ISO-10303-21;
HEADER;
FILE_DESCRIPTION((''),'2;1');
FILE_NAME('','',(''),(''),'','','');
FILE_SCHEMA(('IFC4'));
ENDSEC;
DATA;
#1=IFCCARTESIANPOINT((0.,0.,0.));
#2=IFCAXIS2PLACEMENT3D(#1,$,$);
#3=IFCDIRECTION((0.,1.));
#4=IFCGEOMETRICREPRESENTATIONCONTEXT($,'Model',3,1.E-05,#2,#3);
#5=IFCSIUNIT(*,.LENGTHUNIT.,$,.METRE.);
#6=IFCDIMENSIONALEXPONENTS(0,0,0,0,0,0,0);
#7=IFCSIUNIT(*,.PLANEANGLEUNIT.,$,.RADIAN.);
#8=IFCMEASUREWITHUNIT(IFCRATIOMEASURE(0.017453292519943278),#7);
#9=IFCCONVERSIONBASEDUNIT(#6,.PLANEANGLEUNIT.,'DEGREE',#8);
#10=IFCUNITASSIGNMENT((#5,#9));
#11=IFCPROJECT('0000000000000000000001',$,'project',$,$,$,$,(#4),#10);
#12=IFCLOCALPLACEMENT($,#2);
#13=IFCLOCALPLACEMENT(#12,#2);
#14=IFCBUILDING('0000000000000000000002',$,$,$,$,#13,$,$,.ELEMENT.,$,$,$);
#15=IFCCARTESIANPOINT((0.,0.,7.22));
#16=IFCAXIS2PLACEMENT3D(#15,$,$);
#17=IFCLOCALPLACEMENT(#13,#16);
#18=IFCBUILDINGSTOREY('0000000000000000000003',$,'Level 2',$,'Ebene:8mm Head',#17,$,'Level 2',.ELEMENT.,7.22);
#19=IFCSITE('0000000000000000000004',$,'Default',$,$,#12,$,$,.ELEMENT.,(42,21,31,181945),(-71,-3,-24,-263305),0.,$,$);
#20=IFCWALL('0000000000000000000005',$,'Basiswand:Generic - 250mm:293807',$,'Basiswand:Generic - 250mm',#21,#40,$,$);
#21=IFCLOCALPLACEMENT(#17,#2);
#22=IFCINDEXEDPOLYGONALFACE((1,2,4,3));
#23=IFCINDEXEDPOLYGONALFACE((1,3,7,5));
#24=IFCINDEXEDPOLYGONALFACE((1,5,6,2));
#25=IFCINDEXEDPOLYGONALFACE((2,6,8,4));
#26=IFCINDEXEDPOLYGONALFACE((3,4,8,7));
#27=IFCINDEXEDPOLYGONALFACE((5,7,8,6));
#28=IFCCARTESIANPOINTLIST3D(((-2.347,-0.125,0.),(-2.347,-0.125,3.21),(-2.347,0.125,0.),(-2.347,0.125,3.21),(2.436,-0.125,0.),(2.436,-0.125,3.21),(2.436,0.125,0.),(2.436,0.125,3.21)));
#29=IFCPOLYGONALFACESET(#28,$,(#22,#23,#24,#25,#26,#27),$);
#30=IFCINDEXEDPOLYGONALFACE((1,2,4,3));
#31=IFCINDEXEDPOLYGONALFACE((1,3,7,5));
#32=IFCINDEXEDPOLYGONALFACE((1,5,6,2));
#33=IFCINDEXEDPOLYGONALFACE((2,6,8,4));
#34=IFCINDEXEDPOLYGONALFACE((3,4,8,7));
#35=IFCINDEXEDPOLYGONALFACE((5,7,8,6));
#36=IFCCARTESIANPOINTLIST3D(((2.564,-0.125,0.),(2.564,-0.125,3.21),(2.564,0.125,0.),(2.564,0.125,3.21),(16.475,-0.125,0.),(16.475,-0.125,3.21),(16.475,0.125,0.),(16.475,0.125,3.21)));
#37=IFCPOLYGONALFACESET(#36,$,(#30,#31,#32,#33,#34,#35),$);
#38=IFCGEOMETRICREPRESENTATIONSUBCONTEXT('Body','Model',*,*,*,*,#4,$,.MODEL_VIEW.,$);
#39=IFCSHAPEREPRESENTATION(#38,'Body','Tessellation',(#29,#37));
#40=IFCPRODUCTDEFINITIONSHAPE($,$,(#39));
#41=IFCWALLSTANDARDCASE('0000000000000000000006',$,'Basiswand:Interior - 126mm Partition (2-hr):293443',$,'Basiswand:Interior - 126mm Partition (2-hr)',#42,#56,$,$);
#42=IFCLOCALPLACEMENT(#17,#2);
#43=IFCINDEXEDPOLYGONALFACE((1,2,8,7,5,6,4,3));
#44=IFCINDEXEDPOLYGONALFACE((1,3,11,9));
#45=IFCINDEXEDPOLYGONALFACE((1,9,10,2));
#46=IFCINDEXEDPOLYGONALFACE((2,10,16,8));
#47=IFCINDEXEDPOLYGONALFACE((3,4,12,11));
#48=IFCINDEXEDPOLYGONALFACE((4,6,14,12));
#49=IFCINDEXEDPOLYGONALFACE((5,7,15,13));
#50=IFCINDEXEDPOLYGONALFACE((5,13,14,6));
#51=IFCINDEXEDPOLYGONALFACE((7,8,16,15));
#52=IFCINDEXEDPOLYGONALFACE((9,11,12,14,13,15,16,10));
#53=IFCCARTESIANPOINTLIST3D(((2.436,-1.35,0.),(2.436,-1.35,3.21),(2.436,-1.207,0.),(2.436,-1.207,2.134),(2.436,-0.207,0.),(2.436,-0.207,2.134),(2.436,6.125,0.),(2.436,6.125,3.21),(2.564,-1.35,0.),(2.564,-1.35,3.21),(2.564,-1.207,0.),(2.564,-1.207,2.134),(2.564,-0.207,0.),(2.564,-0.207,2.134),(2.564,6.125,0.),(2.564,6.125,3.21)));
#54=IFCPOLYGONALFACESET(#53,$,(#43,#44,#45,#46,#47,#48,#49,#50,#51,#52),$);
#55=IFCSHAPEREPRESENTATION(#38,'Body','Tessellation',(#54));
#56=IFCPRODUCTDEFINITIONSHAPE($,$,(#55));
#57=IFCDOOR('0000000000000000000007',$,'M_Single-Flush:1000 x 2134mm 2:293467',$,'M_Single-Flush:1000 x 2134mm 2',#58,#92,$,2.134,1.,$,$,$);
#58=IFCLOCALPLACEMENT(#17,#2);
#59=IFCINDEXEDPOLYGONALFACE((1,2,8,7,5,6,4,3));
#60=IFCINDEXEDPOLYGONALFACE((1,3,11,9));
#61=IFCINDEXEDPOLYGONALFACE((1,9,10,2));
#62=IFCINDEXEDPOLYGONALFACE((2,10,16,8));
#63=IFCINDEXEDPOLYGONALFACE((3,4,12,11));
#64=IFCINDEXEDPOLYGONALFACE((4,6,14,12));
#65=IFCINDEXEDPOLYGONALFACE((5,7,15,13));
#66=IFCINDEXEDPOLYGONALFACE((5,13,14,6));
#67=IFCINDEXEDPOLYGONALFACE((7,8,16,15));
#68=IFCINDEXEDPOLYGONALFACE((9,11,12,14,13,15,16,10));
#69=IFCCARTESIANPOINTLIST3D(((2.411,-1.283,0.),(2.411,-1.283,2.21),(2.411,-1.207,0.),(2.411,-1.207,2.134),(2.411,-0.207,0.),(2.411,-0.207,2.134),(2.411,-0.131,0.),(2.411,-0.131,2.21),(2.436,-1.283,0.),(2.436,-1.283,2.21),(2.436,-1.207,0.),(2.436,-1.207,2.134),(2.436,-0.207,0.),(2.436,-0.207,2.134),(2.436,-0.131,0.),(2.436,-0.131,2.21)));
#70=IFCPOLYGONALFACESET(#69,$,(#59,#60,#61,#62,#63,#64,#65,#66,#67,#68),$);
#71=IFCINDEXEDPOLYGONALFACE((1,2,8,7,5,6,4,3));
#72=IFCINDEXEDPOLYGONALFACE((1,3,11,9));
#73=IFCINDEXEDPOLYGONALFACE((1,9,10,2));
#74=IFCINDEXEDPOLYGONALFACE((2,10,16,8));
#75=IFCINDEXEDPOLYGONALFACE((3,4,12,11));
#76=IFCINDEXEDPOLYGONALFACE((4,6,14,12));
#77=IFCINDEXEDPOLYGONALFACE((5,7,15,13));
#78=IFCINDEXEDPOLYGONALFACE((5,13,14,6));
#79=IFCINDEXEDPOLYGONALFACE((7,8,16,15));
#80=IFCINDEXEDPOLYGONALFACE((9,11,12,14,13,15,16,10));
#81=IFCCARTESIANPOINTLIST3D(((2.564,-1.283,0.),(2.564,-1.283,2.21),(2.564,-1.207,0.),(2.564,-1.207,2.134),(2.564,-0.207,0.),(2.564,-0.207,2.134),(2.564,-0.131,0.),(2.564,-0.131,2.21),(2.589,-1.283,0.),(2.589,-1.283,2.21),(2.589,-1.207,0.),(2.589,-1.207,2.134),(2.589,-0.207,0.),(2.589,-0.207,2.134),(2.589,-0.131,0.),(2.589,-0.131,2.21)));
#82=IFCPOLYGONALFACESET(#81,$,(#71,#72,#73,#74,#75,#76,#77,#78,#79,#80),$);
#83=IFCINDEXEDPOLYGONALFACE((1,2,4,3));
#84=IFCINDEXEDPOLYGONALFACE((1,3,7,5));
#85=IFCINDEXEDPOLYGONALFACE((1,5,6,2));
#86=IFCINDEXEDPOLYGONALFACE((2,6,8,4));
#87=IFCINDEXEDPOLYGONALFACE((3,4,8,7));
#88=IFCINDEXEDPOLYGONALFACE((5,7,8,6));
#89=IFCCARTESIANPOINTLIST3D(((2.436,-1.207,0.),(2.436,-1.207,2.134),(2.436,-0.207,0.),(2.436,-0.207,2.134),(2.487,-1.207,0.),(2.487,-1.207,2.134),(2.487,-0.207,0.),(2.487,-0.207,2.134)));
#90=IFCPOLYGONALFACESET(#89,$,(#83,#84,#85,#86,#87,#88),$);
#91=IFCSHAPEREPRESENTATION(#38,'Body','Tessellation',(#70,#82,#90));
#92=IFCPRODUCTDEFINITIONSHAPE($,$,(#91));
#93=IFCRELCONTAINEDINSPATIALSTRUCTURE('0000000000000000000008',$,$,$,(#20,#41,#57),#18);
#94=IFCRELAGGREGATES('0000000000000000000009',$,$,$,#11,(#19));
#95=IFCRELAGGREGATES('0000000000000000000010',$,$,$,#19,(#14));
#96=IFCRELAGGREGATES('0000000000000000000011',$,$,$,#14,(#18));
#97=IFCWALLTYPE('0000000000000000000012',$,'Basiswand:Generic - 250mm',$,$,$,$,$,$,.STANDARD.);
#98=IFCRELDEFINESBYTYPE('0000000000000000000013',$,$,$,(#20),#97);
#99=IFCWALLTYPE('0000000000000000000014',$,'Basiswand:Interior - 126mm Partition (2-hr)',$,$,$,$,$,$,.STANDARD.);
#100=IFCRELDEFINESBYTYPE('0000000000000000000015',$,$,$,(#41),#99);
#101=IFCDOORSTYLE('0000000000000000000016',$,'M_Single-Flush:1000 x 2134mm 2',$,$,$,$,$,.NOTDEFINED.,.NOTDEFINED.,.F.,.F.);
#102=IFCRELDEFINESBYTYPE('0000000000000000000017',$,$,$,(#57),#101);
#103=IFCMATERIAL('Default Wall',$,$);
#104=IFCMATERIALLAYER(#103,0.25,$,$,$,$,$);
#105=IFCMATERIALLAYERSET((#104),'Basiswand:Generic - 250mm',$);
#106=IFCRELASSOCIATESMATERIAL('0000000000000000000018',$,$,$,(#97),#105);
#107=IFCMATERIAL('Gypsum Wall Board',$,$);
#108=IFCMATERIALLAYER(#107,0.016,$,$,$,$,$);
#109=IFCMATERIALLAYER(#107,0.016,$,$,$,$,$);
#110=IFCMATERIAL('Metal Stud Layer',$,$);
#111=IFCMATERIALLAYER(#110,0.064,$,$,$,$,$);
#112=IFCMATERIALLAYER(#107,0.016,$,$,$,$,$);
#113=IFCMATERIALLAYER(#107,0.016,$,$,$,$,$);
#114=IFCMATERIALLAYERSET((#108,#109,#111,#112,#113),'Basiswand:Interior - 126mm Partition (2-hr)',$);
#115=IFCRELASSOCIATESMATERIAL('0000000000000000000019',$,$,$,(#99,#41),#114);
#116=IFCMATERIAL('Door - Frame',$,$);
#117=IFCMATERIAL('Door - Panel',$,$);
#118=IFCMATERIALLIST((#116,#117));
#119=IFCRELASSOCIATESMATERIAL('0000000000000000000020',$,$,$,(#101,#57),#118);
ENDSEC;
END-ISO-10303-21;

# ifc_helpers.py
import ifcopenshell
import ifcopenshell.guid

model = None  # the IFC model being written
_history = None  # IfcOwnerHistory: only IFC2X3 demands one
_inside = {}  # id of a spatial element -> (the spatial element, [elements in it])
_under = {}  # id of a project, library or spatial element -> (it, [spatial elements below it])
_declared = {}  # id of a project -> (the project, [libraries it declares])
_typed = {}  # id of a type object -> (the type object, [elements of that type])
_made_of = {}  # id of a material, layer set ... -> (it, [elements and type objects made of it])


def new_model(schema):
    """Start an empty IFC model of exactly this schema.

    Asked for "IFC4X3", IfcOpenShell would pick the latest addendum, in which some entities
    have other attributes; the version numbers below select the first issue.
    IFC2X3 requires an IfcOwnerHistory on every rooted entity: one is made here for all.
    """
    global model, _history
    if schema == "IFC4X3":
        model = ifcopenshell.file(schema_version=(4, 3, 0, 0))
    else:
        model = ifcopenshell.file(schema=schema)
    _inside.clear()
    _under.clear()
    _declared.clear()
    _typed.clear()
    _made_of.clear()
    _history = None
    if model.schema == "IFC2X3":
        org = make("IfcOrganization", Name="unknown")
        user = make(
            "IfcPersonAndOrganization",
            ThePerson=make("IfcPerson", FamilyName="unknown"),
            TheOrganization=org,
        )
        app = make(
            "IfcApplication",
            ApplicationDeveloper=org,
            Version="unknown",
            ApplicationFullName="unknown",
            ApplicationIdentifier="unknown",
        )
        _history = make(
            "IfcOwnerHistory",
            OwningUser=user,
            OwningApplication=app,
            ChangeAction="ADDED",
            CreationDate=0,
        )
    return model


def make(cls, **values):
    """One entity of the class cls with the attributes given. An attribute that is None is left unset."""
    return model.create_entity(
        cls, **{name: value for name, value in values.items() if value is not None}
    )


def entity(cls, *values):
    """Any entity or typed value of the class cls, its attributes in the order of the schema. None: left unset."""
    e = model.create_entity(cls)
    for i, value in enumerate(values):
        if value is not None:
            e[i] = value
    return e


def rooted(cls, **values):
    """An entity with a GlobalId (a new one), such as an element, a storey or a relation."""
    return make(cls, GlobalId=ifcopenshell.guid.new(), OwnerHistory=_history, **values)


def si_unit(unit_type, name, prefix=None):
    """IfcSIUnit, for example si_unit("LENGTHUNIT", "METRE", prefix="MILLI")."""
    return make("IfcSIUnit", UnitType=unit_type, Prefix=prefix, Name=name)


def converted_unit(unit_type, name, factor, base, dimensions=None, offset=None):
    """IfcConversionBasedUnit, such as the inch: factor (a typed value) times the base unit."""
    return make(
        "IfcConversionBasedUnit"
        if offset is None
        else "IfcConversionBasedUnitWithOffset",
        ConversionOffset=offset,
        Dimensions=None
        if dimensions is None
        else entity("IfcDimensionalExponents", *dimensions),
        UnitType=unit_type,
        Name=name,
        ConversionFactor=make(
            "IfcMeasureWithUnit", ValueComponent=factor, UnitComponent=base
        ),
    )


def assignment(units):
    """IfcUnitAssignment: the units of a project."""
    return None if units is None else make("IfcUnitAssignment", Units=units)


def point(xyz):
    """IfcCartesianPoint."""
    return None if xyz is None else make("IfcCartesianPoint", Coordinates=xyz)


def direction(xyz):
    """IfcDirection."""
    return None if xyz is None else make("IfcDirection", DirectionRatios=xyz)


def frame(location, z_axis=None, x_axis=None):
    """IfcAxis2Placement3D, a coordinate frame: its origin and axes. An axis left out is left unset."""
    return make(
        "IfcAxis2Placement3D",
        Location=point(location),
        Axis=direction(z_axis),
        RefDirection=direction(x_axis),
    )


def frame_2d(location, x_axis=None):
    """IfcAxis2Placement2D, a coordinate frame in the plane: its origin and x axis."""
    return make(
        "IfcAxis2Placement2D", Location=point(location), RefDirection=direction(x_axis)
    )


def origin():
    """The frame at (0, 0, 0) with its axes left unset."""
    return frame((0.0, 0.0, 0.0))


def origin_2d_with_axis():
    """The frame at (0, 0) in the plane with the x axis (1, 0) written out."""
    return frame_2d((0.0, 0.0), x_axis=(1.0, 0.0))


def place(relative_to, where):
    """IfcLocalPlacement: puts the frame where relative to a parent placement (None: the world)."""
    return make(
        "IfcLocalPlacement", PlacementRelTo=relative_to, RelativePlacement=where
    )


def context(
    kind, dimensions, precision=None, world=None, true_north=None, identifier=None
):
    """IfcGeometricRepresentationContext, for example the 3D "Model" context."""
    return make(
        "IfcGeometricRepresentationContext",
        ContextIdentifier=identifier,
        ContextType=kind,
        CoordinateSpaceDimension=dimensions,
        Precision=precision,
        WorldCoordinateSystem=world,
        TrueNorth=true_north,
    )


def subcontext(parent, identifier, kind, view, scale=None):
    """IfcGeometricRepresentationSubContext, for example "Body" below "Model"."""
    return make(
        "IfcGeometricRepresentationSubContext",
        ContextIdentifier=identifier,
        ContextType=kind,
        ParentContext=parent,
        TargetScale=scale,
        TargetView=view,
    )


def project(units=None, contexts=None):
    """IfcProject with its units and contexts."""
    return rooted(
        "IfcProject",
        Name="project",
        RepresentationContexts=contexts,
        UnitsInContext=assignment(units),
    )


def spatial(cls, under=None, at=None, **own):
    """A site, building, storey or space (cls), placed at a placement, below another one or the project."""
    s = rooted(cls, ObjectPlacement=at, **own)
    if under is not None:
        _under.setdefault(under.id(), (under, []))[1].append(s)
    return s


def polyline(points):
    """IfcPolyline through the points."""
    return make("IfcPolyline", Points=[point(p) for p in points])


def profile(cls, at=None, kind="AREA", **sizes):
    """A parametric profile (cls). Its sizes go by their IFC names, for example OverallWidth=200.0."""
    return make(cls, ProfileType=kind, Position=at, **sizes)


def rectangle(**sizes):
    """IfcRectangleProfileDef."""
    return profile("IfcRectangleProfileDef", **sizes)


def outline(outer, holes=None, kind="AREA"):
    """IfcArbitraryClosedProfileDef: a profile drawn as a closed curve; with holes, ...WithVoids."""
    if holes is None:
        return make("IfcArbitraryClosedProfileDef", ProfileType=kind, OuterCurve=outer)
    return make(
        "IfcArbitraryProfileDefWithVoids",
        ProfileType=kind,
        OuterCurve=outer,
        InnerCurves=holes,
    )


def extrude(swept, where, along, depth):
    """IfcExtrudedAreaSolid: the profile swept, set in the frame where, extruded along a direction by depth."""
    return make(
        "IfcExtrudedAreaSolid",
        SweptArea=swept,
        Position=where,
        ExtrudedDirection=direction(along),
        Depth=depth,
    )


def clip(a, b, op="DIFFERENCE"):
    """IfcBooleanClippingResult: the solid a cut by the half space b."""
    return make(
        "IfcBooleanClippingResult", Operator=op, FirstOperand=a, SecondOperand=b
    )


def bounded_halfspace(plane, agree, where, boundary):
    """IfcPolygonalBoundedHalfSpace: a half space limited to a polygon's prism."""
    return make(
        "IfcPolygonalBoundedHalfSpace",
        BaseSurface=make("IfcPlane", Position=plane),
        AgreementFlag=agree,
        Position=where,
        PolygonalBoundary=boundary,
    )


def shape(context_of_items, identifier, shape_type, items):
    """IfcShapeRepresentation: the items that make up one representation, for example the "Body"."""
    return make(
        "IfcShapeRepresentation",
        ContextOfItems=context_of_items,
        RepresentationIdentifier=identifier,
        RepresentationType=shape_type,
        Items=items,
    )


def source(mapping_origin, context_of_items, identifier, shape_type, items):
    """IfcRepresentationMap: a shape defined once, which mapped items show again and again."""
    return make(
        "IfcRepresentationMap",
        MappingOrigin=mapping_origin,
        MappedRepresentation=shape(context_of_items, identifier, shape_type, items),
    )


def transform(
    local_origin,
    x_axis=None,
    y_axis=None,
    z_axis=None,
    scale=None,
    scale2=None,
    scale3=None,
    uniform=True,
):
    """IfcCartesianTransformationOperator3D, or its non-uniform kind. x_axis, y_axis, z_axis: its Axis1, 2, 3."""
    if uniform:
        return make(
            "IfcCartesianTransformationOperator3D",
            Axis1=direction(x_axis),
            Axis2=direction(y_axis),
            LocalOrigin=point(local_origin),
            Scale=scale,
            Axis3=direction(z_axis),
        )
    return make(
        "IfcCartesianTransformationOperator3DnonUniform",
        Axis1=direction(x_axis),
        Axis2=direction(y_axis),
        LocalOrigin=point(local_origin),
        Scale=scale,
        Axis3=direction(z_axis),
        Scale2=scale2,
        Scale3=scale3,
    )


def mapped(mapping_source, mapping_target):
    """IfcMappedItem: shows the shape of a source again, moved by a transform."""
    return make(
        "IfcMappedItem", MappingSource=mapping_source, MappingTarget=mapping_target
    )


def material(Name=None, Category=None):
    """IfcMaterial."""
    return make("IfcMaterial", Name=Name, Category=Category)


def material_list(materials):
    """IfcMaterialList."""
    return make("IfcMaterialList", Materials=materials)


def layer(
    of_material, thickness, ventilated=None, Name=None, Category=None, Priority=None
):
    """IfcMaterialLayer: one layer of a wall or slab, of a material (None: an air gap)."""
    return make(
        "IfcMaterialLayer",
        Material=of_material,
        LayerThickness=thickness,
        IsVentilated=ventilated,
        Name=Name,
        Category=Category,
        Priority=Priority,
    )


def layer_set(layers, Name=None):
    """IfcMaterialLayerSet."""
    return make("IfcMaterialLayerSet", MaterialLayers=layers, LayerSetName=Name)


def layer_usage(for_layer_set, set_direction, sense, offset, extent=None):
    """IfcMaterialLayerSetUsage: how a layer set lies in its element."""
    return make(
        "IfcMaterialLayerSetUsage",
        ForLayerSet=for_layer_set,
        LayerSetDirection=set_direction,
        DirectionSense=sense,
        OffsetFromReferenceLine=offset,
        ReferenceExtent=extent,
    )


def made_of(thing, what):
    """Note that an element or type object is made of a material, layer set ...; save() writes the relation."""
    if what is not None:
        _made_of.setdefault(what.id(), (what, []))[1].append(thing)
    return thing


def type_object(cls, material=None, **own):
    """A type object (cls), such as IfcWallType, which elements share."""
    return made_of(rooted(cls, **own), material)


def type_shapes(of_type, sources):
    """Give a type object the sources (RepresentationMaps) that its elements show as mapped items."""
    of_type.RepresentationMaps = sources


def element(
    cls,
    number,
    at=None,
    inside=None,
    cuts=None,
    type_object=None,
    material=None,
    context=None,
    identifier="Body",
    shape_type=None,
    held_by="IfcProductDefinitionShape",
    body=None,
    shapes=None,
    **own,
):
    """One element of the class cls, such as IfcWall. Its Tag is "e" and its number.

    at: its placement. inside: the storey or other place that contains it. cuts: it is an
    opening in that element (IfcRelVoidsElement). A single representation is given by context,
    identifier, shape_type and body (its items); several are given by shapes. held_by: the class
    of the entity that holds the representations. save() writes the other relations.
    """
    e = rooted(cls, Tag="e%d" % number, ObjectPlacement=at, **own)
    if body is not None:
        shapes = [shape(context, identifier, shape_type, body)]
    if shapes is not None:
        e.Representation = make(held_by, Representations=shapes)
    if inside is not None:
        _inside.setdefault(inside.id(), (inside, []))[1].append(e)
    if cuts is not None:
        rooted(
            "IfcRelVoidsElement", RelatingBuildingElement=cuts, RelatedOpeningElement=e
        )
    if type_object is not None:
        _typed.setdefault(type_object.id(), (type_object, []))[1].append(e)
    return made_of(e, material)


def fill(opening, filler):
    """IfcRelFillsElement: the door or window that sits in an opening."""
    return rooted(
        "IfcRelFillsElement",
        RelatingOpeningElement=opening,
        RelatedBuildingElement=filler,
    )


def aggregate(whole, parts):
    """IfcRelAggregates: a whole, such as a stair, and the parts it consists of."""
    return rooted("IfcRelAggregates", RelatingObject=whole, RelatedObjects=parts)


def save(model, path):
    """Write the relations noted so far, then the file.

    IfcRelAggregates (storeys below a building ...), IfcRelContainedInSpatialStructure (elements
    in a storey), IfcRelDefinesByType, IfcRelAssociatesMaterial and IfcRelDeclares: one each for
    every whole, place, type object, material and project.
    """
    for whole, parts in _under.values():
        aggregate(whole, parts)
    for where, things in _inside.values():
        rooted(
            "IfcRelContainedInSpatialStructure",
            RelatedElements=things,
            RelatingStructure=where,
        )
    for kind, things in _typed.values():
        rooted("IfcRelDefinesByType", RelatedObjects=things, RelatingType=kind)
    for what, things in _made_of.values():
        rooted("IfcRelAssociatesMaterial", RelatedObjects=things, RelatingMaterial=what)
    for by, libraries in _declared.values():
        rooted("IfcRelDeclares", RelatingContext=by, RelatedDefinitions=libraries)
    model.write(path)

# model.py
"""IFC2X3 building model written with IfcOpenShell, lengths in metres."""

from ifc_helpers import new_model, entity, si_unit, converted_unit, direction, frame, frame_2d, origin, origin_2d_with_axis, place, context, subcontext, project, spatial, polyline, rectangle, outline, extrude, clip, bounded_halfspace, source, transform, mapped, material, material_list, layer, layer_set, layer_usage, type_object, type_shapes, element, fill, save


model = new_model("IFC2X3")

# Units and contexts
model_context = context("Model", 3, precision=1e-05, world=origin(), true_north=direction((0.0, 1.0)))
body_context = subcontext(model_context, "Body", "Model", "MODEL_VIEW")
ifc_project = project(units=[si_unit("LENGTHUNIT", "METRE"), converted_unit("PLANEANGLEUNIT", "DEGREE", entity("IfcRatioMeasure", 0.017453292519943278), si_unit("PLANEANGLEUNIT", "RADIAN"), dimensions=[0, 0, 0, 0, 0, 0, 0])], contexts=[model_context])

# Site, building, storey
site_placement = place(None, origin())
site = spatial("IfcSite", under=ifc_project, at=site_placement, Name="Default", CompositionType="ELEMENT", RefLatitude=(42, 21, 31, 181945), RefLongitude=(-71, -3, -24, -263305), RefElevation=0.0)
building_placement = place(site_placement, origin())
building = spatial("IfcBuilding", under=site, at=building_placement, CompositionType="ELEMENT")
storey_placement = place(building_placement, frame((0.0, 0.0, 7.22)))
storey = spatial("IfcBuildingStorey", under=building, at=storey_placement, Name="Level 2", ObjectType="Ebene:8mm Head", LongName="Level 2", CompositionType="ELEMENT", Elevation=7.22)

# Wall
ifc_material_1 = material(Name="Default Wall")
ifc_layer_1 = layer(ifc_material_1, 0.25)
ifc_layer_set_1 = layer_set([ifc_layer_1], Name="Basiswand:Generic - 250mm")
wall_type_1 = type_object("IfcWallType", Name="Basiswand:Generic - 250mm", PredefinedType="STANDARD", material=ifc_layer_set_1)
wall_1_placement = place(storey_placement, frame((-2.347, 0.0, 0.0)))
element("IfcWall", 1, at=wall_1_placement, inside=storey, type_object=wall_type_1, Name="Basiswand:Generic - 250mm:293807", ObjectType="Basiswand:Generic - 250mm", context=body_context, shape_type="SweptSolid", body=[
    extrude(rectangle(XDim=4.783, YDim=0.25, at=frame_2d((0.0, 0.0), x_axis=(1.0, 0.0))), frame((2.3915, 0.0, 0.0)), (0.0, 0.0, 1.0), 3.21),
    extrude(rectangle(XDim=13.911, YDim=0.25, at=origin_2d_with_axis()), frame((11.8665, 0.0, 0.0), z_axis=(0.0, 0.0, 1.0), x_axis=(-1.0, 0.0, 0.0)), (0.0, 0.0, 1.0), 3.21),
])

# Wall, opening, door
ifc_material_2 = material(Name="Gypsum Wall Board")
ifc_layer_2 = layer(ifc_material_2, 0.016)
ifc_layer_3 = layer(ifc_material_2, 0.016)
ifc_material_3 = material(Name="Metal Stud Layer")
ifc_layer_4 = layer(ifc_material_3, 0.064)
ifc_layer_5 = layer(ifc_material_2, 0.016)
ifc_layer_6 = layer(ifc_material_2, 0.016)
ifc_layer_set_2 = layer_set([ifc_layer_2, ifc_layer_3, ifc_layer_4, ifc_layer_5, ifc_layer_6], Name="Basiswand:Interior - 126mm Partition (2-hr)")
ifc_layer_usage_1 = layer_usage(ifc_layer_set_2, "AXIS2", "POSITIVE", -0.064)
wall_type_2 = type_object("IfcWallType", Name="Basiswand:Interior - 126mm Partition (2-hr)", PredefinedType="STANDARD", material=ifc_layer_set_2)
wall_2_placement = place(storey_placement, frame((2.5, -1.35, 0.0), z_axis=(0.0, 0.0, 1.0), x_axis=(0.0, 1.0, 0.0)))
wall_2 = element("IfcWallStandardCase", 2, at=wall_2_placement, inside=storey, type_object=wall_type_2, material=ifc_layer_usage_1, Name="Basiswand:Interior - 126mm Partition (2-hr):293443", ObjectType="Basiswand:Interior - 126mm Partition (2-hr)", context=body_context, shape_type="Clipping", body=[
    clip(extrude(rectangle(XDim=7.475, YDim=0.128, at=frame_2d((3.7375, 0.0), x_axis=(-1.0, 0.0))), origin(), (0.0, 0.0, 1.0), 3.21), bounded_halfspace(frame((0.0, -0.064, 3.21), z_axis=(0.0, 0.0, -1.0), x_axis=(1.0, 0.0, 0.0)), True, frame((0.0, -0.064, 3.21)), polyline([(0.0, 0.0), (1.475, 0.0), (7.475, 0.0), (7.475, 0.128), (6.456, 0.128), (6.328, 0.128), (4.328, 0.128), (4.2, 0.128), (0.0, 0.128), (0.0, 0.0)]))),
])
opening_1_placement = place(wall_2_placement, frame((0.143, -0.064, 0.0)))
opening_1 = element("IfcOpeningElement", 3, at=opening_1_placement, cuts=wall_2, ObjectType="Opening", context=body_context, shape_type="SweptSolid", body=[
    extrude(rectangle(XDim=1.0, YDim=2.134, at=frame_2d((1.067, 0.5), x_axis=(0.0, 1.0))), frame((0.0, 0.0, 0.0), z_axis=(0.0, 1.0, 0.0), x_axis=(0.0, 0.0, 1.0)), (0.0, 0.0, 1.0), 0.128),
])
ifc_material_4 = material(Name="Door - Frame")
ifc_material_5 = material(Name="Door - Panel")
ifc_material_list = material_list([ifc_material_4, ifc_material_5])
door_style_1 = type_object("IfcDoorStyle", Name="M_Single-Flush:1000 x 2134mm 2", ConstructionType="NOTDEFINED", OperationType="NOTDEFINED", ParameterTakesPrecedence=False, Sizeable=False, material=ifc_material_list)
shared_shape_1 = source(origin(), body_context, "Body", "SweptSolid", [
    extrude(outline(polyline([(-0.576, -1.124), (0.576, -1.124), (0.576, 1.086), (0.5, 1.086), (0.5, -1.048), (-0.5, -1.048), (-0.5, 1.086), (-0.576, 1.086), (-0.576, -1.124)])), frame((0.5, 0.128, 1.086), z_axis=(0.0, 1.0, 0.0), x_axis=(1.0, 0.0, 0.0)), (0.0, 0.0, 1.0), 0.025),
    extrude(outline(polyline([(-1.124, -0.576), (1.086, -0.576), (1.086, -0.5), (-1.048, -0.5), (-1.048, 0.5), (1.086, 0.5), (1.086, 0.576), (-1.124, 0.576), (-1.124, -0.576)])), frame((0.5, -0.025, 1.086), z_axis=(0.0, 1.0, 0.0), x_axis=(0.0, 0.0, -1.0)), (0.0, 0.0, 1.0), 0.025),
    extrude(rectangle(XDim=0.051, YDim=1.0, at=frame_2d((0.0, 0.0), x_axis=(1.0, 0.0))), frame((0.5, 0.1025, 0.0), z_axis=(0.0, 0.0, 1.0), x_axis=(0.0, 1.0, 0.0)), (0.0, 0.0, 1.0), 2.134),
])
type_shapes(door_style_1, [shared_shape_1])
door_1_placement = place(opening_1_placement, origin())
door_1 = element("IfcDoor", 4, at=door_1_placement, inside=storey, type_object=door_style_1, material=ifc_material_list, Name="M_Single-Flush:1000 x 2134mm 2:293467", ObjectType="M_Single-Flush:1000 x 2134mm 2", OverallHeight=2.134, OverallWidth=1.0, context=body_context, shape_type="MappedRepresentation", body=[
    mapped(shared_shape_1, transform((0.0, 0.0, 0.0), scale=1.0)),
])
fill(opening_1, door_1)

save(model, "model.ifc")
